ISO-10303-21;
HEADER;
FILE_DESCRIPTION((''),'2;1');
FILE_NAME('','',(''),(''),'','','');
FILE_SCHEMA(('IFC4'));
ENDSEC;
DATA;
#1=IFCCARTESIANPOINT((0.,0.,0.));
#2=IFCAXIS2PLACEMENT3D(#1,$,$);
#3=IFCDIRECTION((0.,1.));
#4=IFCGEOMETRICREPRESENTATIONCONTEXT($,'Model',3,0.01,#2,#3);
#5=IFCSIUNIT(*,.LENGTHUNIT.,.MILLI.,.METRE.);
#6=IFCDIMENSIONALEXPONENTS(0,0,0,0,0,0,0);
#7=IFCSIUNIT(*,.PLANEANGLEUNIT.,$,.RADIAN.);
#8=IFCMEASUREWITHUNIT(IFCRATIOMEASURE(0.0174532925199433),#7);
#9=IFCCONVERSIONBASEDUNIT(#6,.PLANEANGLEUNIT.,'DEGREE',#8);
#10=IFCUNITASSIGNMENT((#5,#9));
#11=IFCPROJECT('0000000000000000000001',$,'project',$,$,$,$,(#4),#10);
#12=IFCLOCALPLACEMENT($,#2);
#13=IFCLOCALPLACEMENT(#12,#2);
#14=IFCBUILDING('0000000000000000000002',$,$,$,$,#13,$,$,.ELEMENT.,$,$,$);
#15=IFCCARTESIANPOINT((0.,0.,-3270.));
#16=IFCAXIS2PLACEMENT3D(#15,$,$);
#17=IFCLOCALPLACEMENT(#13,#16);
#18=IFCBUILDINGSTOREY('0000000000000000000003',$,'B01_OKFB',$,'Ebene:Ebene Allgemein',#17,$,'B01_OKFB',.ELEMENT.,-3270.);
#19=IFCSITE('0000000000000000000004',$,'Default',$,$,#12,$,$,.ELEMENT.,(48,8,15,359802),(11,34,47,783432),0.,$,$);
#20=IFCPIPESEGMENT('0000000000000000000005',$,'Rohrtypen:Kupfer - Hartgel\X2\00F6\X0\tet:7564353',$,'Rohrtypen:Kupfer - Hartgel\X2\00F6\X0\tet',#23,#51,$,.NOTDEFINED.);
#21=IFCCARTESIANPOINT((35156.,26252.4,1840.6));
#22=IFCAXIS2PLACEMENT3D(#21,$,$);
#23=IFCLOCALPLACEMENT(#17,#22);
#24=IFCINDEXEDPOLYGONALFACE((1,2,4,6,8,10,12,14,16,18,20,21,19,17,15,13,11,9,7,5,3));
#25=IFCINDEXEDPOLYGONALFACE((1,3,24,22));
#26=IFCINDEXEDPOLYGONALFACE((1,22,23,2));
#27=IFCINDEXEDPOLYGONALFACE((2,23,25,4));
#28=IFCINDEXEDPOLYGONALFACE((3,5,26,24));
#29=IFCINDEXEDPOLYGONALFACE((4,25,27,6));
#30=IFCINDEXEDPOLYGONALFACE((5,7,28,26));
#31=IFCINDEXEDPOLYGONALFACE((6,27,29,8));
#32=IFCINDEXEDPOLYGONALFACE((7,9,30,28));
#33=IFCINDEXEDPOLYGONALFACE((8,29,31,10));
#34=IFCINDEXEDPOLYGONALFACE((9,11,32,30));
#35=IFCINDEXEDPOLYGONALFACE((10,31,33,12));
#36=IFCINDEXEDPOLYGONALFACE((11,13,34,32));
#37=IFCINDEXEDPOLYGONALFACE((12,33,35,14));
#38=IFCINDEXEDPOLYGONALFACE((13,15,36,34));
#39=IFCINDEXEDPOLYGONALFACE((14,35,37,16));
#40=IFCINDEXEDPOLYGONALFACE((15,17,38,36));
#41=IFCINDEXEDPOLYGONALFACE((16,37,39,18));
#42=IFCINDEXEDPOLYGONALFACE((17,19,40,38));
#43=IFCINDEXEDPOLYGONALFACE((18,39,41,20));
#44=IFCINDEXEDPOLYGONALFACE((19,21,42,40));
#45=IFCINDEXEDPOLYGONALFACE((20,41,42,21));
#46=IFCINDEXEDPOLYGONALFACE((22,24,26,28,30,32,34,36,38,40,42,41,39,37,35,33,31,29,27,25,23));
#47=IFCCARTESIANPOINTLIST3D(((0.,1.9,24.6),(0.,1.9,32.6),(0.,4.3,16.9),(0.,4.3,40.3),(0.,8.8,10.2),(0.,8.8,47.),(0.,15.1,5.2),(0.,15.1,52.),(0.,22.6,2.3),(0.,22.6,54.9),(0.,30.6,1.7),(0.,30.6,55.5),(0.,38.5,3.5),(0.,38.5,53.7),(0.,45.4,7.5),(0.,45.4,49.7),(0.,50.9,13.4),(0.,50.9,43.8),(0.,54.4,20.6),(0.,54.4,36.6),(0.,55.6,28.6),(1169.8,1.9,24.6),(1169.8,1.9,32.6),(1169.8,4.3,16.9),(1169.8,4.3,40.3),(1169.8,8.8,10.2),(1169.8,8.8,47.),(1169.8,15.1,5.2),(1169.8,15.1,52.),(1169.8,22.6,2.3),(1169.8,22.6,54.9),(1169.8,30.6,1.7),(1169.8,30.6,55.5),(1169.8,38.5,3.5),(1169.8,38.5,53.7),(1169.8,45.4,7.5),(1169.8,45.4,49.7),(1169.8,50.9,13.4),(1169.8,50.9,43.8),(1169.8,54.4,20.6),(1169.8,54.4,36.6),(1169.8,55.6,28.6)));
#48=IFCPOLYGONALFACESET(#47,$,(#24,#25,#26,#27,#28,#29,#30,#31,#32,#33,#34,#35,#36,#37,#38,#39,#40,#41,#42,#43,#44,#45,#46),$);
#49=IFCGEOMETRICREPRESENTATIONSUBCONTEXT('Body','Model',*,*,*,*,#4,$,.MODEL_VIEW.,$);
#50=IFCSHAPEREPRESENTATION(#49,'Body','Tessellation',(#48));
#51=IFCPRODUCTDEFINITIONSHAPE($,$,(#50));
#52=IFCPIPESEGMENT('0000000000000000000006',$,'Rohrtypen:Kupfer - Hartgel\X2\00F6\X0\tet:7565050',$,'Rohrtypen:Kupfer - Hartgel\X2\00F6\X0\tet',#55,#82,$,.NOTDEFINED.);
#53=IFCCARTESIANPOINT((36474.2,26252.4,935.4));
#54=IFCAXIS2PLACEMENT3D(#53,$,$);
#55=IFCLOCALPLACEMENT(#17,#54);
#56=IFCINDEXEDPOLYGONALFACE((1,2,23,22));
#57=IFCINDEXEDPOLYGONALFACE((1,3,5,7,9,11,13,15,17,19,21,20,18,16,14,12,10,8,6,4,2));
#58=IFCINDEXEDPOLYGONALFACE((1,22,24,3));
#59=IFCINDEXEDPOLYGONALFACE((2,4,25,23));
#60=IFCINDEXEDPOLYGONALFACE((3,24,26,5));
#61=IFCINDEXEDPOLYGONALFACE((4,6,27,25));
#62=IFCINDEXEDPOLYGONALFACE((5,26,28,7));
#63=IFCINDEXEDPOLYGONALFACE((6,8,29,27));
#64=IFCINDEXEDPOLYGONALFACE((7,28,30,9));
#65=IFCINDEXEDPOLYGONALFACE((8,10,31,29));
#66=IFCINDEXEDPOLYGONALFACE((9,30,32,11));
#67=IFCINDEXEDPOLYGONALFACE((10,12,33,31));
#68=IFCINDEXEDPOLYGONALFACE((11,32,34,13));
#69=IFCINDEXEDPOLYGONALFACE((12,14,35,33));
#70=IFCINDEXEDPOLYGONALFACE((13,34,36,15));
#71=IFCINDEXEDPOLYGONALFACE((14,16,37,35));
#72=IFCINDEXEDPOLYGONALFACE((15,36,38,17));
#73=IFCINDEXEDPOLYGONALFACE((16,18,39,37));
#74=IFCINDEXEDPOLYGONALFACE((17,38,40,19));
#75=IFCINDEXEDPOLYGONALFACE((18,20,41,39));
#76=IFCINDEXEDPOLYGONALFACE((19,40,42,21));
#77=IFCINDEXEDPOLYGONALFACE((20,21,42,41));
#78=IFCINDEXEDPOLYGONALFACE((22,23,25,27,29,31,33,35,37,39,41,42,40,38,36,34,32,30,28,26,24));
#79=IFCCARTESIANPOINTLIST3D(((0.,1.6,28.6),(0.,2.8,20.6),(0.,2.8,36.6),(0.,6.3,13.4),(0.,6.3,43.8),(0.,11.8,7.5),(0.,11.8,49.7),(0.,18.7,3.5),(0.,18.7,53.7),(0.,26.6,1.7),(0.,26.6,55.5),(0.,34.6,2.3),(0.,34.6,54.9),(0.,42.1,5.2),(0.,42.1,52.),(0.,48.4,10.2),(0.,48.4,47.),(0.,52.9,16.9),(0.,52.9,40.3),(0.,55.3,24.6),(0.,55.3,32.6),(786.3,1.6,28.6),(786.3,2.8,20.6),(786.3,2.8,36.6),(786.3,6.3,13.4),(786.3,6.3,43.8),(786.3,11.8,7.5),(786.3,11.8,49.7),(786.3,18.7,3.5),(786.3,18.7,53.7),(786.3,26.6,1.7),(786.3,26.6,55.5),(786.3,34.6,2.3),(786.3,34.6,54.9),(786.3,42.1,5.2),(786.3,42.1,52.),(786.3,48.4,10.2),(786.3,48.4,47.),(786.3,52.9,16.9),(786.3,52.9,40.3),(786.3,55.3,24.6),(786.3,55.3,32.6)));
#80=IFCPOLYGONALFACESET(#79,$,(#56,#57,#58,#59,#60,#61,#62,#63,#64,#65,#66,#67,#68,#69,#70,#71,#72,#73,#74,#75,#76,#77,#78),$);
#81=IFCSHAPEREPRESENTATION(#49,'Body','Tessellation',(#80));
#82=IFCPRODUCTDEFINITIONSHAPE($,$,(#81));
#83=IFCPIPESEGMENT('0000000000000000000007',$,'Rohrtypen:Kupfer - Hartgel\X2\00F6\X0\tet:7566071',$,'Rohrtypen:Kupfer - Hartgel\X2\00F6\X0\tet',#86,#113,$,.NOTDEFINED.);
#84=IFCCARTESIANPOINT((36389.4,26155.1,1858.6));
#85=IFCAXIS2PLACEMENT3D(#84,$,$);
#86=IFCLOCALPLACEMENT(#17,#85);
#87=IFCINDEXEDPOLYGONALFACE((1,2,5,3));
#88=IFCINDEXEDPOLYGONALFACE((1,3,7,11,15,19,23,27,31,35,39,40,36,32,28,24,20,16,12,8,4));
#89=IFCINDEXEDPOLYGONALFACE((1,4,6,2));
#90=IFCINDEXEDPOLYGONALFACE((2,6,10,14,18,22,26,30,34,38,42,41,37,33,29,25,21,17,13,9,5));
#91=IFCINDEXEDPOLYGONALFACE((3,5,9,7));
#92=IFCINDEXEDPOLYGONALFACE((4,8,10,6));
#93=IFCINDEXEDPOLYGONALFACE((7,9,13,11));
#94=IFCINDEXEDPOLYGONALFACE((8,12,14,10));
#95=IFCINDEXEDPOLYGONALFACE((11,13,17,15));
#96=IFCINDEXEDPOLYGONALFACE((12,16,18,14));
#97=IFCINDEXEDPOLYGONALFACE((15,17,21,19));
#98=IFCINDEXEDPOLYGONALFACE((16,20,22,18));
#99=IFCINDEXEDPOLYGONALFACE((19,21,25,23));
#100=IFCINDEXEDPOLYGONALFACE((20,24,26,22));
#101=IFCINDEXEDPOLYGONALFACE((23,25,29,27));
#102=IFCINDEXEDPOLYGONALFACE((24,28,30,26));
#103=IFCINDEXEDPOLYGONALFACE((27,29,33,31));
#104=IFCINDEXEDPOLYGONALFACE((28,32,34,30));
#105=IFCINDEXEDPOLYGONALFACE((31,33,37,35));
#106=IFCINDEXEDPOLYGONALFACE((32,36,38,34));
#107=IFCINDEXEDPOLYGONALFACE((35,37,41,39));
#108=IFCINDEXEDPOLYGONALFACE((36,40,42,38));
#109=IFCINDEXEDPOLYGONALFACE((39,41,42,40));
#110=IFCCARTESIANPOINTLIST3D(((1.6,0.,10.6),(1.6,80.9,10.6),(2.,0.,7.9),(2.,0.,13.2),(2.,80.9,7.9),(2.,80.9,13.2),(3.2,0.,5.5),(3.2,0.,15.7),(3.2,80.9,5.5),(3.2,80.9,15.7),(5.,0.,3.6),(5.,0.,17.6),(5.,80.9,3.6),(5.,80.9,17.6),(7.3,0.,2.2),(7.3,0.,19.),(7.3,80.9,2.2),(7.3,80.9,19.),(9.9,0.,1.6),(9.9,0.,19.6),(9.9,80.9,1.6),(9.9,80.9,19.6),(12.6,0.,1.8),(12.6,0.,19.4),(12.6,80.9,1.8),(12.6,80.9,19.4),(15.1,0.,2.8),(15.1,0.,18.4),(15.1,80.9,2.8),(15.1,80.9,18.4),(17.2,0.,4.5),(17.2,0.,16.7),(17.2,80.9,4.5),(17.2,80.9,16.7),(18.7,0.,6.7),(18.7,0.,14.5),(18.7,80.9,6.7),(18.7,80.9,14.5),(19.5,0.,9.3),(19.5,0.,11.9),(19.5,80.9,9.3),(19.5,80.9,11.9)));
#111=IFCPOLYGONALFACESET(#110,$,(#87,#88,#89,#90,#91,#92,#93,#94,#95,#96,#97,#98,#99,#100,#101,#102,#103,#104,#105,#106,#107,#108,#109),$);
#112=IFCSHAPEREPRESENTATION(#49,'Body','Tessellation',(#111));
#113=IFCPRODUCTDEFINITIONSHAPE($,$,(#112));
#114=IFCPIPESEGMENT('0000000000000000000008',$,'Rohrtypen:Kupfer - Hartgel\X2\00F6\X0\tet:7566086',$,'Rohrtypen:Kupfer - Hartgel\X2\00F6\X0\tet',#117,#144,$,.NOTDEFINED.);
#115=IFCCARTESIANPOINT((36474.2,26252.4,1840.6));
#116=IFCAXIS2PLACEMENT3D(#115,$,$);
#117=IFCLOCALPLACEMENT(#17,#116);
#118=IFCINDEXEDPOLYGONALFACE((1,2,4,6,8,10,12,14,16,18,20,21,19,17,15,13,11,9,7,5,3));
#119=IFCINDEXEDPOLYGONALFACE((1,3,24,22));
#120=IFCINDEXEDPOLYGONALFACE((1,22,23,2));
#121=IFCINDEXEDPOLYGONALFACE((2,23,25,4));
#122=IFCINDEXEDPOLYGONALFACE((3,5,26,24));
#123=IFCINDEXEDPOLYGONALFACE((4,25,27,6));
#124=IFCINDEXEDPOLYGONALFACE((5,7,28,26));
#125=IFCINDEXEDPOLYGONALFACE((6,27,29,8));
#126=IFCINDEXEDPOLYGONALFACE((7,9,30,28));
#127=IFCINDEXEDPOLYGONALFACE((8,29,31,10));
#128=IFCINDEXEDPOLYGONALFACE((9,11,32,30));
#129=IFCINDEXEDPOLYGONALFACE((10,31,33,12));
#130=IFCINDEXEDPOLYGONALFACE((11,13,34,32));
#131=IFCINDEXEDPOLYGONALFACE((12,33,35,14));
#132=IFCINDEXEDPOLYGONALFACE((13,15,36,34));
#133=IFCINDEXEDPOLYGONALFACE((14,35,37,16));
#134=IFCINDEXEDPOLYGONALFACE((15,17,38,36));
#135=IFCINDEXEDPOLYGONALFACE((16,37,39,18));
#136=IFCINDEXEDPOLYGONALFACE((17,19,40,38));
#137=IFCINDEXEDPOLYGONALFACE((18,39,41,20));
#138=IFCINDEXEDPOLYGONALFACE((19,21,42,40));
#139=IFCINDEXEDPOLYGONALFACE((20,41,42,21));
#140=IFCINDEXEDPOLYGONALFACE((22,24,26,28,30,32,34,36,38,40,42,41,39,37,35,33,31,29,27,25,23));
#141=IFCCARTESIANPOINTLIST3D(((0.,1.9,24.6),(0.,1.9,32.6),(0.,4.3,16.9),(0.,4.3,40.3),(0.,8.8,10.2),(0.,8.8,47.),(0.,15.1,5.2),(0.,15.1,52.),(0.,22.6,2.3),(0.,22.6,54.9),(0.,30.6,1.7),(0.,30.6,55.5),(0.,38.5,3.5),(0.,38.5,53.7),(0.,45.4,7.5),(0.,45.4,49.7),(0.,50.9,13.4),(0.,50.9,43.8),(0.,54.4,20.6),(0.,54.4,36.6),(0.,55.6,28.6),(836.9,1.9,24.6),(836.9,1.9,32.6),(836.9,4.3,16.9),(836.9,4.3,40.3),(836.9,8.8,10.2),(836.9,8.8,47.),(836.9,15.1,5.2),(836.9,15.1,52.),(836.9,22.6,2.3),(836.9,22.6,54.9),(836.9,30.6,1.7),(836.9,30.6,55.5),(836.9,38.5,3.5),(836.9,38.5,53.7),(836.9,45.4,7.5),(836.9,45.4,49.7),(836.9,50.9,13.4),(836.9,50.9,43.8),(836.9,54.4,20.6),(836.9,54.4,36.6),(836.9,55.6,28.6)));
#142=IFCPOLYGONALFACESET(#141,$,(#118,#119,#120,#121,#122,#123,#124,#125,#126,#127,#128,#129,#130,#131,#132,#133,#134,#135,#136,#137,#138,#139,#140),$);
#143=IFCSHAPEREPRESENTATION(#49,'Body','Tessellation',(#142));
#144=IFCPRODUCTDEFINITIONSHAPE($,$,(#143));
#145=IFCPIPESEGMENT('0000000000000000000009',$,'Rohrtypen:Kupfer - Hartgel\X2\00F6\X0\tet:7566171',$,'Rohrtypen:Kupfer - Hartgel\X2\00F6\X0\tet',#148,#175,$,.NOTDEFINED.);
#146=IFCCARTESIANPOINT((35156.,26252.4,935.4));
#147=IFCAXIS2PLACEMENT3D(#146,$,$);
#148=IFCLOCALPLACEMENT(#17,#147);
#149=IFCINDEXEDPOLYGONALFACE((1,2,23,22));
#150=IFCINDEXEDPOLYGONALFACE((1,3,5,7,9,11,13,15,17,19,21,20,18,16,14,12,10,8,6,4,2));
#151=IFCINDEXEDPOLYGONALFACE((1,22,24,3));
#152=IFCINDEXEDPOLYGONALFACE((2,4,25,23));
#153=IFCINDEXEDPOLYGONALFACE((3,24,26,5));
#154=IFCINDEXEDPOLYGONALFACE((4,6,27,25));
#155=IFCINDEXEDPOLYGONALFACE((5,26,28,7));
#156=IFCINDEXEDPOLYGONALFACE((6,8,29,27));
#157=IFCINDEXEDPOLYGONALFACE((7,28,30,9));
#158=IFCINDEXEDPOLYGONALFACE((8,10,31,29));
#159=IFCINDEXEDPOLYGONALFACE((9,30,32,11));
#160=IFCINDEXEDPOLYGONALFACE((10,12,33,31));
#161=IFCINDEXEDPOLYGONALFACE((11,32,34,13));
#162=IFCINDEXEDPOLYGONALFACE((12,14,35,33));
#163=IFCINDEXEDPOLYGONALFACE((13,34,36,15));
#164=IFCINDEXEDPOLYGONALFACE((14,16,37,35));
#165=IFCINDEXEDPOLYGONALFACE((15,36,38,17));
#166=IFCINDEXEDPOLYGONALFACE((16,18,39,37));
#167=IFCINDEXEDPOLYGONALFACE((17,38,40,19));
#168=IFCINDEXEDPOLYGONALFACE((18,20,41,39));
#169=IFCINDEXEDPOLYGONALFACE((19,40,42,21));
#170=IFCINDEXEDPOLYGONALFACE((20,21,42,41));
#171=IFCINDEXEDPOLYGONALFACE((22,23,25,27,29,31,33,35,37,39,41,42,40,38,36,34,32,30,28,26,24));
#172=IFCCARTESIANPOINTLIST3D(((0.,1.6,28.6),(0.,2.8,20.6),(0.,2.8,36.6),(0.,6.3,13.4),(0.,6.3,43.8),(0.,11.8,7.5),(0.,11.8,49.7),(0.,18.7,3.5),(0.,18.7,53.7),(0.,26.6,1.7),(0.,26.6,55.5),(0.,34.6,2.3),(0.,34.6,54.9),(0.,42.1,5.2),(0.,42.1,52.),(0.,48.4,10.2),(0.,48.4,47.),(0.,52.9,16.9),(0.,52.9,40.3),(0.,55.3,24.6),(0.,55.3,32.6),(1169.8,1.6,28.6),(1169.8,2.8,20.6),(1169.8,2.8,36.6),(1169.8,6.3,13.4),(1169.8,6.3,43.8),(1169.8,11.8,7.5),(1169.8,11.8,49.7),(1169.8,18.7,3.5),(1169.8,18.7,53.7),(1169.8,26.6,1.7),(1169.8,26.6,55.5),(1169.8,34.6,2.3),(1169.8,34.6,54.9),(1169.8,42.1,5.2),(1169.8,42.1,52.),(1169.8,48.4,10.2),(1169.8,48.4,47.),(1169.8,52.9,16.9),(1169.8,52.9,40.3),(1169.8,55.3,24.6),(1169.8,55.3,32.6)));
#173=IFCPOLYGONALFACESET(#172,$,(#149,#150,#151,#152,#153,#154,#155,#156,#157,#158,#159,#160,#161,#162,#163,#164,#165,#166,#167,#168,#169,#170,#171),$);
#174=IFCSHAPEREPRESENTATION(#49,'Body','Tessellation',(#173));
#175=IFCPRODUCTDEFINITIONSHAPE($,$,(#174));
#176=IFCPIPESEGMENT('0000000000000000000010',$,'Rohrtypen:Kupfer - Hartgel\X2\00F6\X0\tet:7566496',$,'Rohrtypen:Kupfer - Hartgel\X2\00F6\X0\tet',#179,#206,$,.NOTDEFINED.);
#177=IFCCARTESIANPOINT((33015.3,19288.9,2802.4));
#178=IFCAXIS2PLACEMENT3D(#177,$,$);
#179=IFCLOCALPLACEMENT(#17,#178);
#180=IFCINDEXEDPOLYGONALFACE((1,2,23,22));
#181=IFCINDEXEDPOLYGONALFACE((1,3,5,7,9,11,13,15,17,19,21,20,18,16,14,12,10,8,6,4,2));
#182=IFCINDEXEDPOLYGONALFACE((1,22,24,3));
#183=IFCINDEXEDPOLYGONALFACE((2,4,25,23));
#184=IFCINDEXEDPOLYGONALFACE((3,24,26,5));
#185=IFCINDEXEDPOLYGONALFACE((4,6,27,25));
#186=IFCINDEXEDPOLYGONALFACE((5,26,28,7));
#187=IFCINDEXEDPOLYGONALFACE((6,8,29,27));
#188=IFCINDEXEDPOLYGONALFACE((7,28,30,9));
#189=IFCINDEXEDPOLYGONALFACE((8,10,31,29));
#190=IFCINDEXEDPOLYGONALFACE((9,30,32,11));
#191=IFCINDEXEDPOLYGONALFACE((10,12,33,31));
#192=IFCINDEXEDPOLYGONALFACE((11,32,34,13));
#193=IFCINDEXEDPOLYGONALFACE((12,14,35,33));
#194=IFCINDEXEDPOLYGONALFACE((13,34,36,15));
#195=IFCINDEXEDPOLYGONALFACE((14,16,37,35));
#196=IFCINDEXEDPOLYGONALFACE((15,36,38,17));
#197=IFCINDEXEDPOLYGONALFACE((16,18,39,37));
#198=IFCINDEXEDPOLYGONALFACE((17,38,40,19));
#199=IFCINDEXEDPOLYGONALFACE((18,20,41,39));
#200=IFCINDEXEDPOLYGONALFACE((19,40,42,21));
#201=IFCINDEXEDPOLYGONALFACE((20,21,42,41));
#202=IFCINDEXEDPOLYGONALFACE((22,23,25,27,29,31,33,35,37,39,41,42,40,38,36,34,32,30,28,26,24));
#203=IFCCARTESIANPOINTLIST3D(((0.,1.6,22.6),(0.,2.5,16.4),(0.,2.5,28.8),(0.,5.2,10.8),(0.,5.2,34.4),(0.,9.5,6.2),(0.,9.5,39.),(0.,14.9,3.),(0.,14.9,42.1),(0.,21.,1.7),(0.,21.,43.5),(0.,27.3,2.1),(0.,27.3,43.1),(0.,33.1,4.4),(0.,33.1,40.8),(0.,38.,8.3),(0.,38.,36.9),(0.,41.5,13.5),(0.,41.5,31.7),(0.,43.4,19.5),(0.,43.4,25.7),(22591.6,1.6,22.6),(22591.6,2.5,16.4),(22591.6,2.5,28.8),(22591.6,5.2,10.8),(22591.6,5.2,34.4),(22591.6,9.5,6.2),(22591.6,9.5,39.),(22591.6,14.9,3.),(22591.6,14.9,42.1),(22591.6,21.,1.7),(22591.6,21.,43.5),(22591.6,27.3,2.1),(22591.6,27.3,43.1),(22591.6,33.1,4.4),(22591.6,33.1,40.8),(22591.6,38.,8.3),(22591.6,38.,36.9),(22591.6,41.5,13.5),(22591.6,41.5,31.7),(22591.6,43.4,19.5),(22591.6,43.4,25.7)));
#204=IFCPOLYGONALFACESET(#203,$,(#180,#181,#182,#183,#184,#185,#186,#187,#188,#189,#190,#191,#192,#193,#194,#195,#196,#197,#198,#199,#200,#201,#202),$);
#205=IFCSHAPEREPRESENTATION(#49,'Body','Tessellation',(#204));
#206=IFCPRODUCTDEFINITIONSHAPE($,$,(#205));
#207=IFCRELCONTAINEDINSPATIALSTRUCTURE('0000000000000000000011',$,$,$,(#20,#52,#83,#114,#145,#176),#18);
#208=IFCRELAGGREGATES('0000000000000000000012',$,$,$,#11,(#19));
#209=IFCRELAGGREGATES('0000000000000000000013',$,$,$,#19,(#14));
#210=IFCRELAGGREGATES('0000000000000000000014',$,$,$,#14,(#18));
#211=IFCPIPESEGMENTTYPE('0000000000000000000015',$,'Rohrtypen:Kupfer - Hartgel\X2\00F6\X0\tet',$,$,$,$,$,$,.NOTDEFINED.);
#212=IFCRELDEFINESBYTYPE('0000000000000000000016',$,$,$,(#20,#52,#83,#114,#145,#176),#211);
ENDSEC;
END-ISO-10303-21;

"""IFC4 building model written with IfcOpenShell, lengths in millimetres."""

from ifc_helpers import new_model, entity, si_unit, converted_unit, direction, frame, frame_2d, origin, origin_2d_with_axis, place, context, subcontext, project, spatial, circle, extrude, type_object, element, save


model = new_model("IFC4")

# Units and contexts
model_context = context("Model", 3, precision=0.01, world=origin(), true_north=direction((0.0, 1.0)))
body_context = subcontext(model_context, "Body", "Model", "MODEL_VIEW")
ifc_project = project(units=[si_unit("LENGTHUNIT", "METRE", prefix="MILLI"), converted_unit("PLANEANGLEUNIT", "DEGREE", entity("IfcRatioMeasure", 0.0174532925199433), si_unit("PLANEANGLEUNIT", "RADIAN"), dimensions=[0, 0, 0, 0, 0, 0, 0])], contexts=[model_context])

# Site, building, storey
site_placement = place(None, origin())
site = spatial("IfcSite", under=ifc_project, at=site_placement, Name="Default", CompositionType="ELEMENT", RefLatitude=(48, 8, 15, 359802), RefLongitude=(11, 34, 47, 783432), RefElevation=0.0)
building_placement = place(site_placement, origin())
building = spatial("IfcBuilding", under=site, at=building_placement, CompositionType="ELEMENT")
storey_placement = place(building_placement, frame((0.0, 0.0, -3270.0)))
storey = spatial("IfcBuildingStorey", under=building, at=storey_placement, Name="B01_OKFB", ObjectType="Ebene:Ebene Allgemein", LongName="B01_OKFB", CompositionType="ELEMENT", Elevation=-3270.0)

# Pipe segments
pipe_segment_type = type_object("IfcPipeSegmentType", Name="Rohrtypen:Kupfer - Hartgelötet", PredefinedType="NOTDEFINED")
pipe_segment_1_placement = place(storey_placement, frame((35156.0, 26252.4, 1840.6)))
element("IfcPipeSegment", 1, at=pipe_segment_1_placement, inside=storey, type_object=pipe_segment_type, Name="Rohrtypen:Kupfer - Hartgelötet:7564353", ObjectType="Rohrtypen:Kupfer - Hartgelötet", PredefinedType="NOTDEFINED", context=body_context, shape_type="SweptSolid", body=[
    extrude(circle(Radius=27.0, at=frame_2d((0.0, 0.0), x_axis=(1.0, 0.0))), frame((0.0, 28.6, 28.6), z_axis=(1.0, 0.0, 0.0), x_axis=(0.0, 1.0, 0.0)), (0.0, 0.0, 1.0), 1169.8),
])
pipe_segment_2_placement = place(storey_placement, frame((36474.2, 26252.4, 935.4)))
element("IfcPipeSegment", 2, at=pipe_segment_2_placement, inside=storey, type_object=pipe_segment_type, Name="Rohrtypen:Kupfer - Hartgelötet:7565050", ObjectType="Rohrtypen:Kupfer - Hartgelötet", PredefinedType="NOTDEFINED", context=body_context, shape_type="SweptSolid", body=[
    extrude(circle(Radius=27.0, at=origin_2d_with_axis()), frame((0.0, 28.6, 28.6), z_axis=(1.0, 0.0, 0.0), x_axis=(0.0, -1.0, 0.0)), (0.0, 0.0, 1.0), 786.3),
])
pipe_segment_3_placement = place(storey_placement, frame((36389.4, 26155.1, 1858.6)))
element("IfcPipeSegment", 3, at=pipe_segment_3_placement, inside=storey, type_object=pipe_segment_type, Name="Rohrtypen:Kupfer - Hartgelötet:7566071", ObjectType="Rohrtypen:Kupfer - Hartgelötet", PredefinedType="NOTDEFINED", context=body_context, shape_type="SweptSolid", body=[
    extrude(circle(Radius=9.0, at=origin_2d_with_axis()), frame((10.6, 0.0, 10.6), z_axis=(0.0, 1.0, 0.0), x_axis=(-1.0, 0.0, 0.0)), (0.0, 0.0, 1.0), 80.9),
])
pipe_segment_4_placement = place(storey_placement, frame((36474.2, 26252.4, 1840.6)))
element("IfcPipeSegment", 4, at=pipe_segment_4_placement, inside=storey, type_object=pipe_segment_type, Name="Rohrtypen:Kupfer - Hartgelötet:7566086", ObjectType="Rohrtypen:Kupfer - Hartgelötet", PredefinedType="NOTDEFINED", context=body_context, shape_type="SweptSolid", body=[
    extrude(circle(Radius=27.0, at=origin_2d_with_axis()), frame((0.0, 28.6, 28.6), z_axis=(1.0, 0.0, 0.0), x_axis=(0.0, 1.0, 0.0)), (0.0, 0.0, 1.0), 836.9),
])
pipe_segment_5_placement = place(storey_placement, frame((35156.0, 26252.4, 935.4)))
element("IfcPipeSegment", 5, at=pipe_segment_5_placement, inside=storey, type_object=pipe_segment_type, Name="Rohrtypen:Kupfer - Hartgelötet:7566171", ObjectType="Rohrtypen:Kupfer - Hartgelötet", PredefinedType="NOTDEFINED", context=body_context, shape_type="SweptSolid", body=[
    extrude(circle(Radius=27.0, at=frame_2d((0.0, 0.0), x_axis=(1.0, 0.0))), frame((0.0, 28.6, 28.6), z_axis=(1.0, 0.0, 0.0), x_axis=(0.0, -1.0, 0.0)), (0.0, 0.0, 1.0), 1169.8),
])
pipe_segment_6_placement = place(storey_placement, frame((33015.3, 19288.9, 2802.4)))
element("IfcPipeSegment", 6, at=pipe_segment_6_placement, inside=storey, type_object=pipe_segment_type, Name="Rohrtypen:Kupfer - Hartgelötet:7566496", ObjectType="Rohrtypen:Kupfer - Hartgelötet", PredefinedType="NOTDEFINED", context=body_context, shape_type="SweptSolid", body=[
    extrude(circle(Radius=21.0, at=origin_2d_with_axis()), frame((0.0, 22.6, 22.6), z_axis=(1.0, 0.0, 0.0), x_axis=(0.0, -1.0, 0.0)), (0.0, 0.0, 1.0), 22591.6),
])

save(model, "model.ifc")
